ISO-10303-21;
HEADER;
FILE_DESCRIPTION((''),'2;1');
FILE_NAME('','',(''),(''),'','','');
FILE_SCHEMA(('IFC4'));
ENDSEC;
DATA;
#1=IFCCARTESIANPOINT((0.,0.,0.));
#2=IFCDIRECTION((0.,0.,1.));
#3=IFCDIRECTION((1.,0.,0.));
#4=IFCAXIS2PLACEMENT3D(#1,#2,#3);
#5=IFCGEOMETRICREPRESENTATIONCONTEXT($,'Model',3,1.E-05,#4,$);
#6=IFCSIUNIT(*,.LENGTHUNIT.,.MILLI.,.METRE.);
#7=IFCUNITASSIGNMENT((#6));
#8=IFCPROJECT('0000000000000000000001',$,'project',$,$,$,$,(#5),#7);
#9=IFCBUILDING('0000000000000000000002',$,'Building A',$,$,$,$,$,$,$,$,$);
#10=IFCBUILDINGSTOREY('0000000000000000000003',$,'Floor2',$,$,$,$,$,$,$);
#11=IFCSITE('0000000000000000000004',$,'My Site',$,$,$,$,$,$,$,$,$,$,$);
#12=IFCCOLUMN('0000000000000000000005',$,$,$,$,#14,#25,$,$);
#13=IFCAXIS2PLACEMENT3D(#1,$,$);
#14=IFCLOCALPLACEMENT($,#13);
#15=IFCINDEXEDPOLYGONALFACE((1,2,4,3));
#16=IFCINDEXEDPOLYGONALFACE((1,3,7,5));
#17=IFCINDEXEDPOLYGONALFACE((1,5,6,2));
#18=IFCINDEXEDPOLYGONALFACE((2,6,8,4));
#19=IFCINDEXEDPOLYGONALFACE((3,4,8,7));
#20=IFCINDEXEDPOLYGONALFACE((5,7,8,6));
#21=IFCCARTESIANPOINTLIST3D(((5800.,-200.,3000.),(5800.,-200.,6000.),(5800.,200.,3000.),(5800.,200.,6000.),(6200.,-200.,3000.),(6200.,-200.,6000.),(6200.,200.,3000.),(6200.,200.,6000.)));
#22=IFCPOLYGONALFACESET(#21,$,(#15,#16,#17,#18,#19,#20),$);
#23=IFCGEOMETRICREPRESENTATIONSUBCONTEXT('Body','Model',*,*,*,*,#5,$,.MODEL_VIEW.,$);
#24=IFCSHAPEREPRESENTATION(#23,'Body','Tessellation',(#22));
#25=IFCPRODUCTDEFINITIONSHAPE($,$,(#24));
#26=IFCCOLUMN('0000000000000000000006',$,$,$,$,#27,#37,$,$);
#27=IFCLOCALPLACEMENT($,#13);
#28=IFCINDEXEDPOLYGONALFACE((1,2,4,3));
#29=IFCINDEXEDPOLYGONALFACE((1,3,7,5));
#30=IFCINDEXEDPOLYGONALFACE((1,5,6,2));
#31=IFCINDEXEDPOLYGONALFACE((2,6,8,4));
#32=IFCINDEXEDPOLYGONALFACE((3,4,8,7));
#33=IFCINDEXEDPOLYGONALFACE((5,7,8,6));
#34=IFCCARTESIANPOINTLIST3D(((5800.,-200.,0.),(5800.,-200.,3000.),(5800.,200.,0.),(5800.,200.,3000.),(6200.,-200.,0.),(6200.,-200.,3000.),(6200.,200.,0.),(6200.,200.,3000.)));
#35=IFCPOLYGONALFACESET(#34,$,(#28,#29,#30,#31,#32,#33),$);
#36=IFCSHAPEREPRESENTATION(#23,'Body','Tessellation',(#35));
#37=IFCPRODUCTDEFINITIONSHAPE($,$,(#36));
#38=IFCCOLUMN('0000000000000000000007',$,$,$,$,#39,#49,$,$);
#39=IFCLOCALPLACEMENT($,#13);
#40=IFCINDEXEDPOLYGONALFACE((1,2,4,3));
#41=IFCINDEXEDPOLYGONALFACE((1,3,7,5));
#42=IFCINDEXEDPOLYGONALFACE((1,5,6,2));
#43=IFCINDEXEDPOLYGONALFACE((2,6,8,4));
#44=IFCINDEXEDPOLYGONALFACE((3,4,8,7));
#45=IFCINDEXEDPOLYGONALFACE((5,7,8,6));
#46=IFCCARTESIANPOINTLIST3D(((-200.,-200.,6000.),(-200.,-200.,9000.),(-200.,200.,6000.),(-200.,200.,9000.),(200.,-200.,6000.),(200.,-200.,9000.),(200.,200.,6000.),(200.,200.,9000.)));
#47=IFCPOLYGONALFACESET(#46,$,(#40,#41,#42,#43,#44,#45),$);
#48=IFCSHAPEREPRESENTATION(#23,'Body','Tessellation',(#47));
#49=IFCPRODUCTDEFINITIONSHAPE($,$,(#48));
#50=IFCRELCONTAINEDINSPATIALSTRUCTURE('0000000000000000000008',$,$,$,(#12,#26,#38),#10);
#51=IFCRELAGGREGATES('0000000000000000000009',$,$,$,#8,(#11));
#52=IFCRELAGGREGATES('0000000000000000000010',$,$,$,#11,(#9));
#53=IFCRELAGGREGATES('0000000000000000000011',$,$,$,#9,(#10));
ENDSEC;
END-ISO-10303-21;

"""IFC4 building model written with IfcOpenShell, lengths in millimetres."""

from ifc_helpers import new_model, si_unit, frame, origin_with_axes, place, context, subcontext, project, spatial, line, indexed_curve, outline, extrude, element, save


model = new_model("IFC4")

# Units and contexts
model_context = context("Model", 3, precision=1e-05, world=origin_with_axes())
body_context = subcontext(model_context, "Body", "Model", "MODEL_VIEW")
ifc_project = project(units=[si_unit("LENGTHUNIT", "METRE", prefix="MILLI")], contexts=[model_context])

# Site, building, storey
site = spatial("IfcSite", under=ifc_project, Name="My Site")
building = spatial("IfcBuilding", under=site, Name="Building A")
storey = spatial("IfcBuildingStorey", under=building, Name="Floor2")

# Columns
for number, where, z_axis, x_axis in (
    (1, (6000.0, 0.0, 3000.0), (0.0, 0.0, 1.0), (1.0, 0.0, 0.0)),
    (2, (6000.0, 0.0, 0.0), (0.0, 0.0, 1.0), (1.0, 0.0, 0.0)),
    (3, (0.0, 0.0, 6000.0), (0.0, 0.0, 1.0), (1.0, 0.0, 0.0)),
):
    element("IfcColumn", number, at=place(None, frame(where, z_axis=z_axis, x_axis=x_axis)), inside=storey, context=body_context, shape_type="SweptSolid", body=[
        extrude(outline(indexed_curve([(-200.0, -200.0), (200.0, -200.0), (200.0, 200.0), (-200.0, 200.0)], segments=[line(1, 2, 3, 4, 1)])), origin_with_axes(), (0.0, 0.0, 1.0), 3000.0),
    ])

save(model, "model.ifc")
